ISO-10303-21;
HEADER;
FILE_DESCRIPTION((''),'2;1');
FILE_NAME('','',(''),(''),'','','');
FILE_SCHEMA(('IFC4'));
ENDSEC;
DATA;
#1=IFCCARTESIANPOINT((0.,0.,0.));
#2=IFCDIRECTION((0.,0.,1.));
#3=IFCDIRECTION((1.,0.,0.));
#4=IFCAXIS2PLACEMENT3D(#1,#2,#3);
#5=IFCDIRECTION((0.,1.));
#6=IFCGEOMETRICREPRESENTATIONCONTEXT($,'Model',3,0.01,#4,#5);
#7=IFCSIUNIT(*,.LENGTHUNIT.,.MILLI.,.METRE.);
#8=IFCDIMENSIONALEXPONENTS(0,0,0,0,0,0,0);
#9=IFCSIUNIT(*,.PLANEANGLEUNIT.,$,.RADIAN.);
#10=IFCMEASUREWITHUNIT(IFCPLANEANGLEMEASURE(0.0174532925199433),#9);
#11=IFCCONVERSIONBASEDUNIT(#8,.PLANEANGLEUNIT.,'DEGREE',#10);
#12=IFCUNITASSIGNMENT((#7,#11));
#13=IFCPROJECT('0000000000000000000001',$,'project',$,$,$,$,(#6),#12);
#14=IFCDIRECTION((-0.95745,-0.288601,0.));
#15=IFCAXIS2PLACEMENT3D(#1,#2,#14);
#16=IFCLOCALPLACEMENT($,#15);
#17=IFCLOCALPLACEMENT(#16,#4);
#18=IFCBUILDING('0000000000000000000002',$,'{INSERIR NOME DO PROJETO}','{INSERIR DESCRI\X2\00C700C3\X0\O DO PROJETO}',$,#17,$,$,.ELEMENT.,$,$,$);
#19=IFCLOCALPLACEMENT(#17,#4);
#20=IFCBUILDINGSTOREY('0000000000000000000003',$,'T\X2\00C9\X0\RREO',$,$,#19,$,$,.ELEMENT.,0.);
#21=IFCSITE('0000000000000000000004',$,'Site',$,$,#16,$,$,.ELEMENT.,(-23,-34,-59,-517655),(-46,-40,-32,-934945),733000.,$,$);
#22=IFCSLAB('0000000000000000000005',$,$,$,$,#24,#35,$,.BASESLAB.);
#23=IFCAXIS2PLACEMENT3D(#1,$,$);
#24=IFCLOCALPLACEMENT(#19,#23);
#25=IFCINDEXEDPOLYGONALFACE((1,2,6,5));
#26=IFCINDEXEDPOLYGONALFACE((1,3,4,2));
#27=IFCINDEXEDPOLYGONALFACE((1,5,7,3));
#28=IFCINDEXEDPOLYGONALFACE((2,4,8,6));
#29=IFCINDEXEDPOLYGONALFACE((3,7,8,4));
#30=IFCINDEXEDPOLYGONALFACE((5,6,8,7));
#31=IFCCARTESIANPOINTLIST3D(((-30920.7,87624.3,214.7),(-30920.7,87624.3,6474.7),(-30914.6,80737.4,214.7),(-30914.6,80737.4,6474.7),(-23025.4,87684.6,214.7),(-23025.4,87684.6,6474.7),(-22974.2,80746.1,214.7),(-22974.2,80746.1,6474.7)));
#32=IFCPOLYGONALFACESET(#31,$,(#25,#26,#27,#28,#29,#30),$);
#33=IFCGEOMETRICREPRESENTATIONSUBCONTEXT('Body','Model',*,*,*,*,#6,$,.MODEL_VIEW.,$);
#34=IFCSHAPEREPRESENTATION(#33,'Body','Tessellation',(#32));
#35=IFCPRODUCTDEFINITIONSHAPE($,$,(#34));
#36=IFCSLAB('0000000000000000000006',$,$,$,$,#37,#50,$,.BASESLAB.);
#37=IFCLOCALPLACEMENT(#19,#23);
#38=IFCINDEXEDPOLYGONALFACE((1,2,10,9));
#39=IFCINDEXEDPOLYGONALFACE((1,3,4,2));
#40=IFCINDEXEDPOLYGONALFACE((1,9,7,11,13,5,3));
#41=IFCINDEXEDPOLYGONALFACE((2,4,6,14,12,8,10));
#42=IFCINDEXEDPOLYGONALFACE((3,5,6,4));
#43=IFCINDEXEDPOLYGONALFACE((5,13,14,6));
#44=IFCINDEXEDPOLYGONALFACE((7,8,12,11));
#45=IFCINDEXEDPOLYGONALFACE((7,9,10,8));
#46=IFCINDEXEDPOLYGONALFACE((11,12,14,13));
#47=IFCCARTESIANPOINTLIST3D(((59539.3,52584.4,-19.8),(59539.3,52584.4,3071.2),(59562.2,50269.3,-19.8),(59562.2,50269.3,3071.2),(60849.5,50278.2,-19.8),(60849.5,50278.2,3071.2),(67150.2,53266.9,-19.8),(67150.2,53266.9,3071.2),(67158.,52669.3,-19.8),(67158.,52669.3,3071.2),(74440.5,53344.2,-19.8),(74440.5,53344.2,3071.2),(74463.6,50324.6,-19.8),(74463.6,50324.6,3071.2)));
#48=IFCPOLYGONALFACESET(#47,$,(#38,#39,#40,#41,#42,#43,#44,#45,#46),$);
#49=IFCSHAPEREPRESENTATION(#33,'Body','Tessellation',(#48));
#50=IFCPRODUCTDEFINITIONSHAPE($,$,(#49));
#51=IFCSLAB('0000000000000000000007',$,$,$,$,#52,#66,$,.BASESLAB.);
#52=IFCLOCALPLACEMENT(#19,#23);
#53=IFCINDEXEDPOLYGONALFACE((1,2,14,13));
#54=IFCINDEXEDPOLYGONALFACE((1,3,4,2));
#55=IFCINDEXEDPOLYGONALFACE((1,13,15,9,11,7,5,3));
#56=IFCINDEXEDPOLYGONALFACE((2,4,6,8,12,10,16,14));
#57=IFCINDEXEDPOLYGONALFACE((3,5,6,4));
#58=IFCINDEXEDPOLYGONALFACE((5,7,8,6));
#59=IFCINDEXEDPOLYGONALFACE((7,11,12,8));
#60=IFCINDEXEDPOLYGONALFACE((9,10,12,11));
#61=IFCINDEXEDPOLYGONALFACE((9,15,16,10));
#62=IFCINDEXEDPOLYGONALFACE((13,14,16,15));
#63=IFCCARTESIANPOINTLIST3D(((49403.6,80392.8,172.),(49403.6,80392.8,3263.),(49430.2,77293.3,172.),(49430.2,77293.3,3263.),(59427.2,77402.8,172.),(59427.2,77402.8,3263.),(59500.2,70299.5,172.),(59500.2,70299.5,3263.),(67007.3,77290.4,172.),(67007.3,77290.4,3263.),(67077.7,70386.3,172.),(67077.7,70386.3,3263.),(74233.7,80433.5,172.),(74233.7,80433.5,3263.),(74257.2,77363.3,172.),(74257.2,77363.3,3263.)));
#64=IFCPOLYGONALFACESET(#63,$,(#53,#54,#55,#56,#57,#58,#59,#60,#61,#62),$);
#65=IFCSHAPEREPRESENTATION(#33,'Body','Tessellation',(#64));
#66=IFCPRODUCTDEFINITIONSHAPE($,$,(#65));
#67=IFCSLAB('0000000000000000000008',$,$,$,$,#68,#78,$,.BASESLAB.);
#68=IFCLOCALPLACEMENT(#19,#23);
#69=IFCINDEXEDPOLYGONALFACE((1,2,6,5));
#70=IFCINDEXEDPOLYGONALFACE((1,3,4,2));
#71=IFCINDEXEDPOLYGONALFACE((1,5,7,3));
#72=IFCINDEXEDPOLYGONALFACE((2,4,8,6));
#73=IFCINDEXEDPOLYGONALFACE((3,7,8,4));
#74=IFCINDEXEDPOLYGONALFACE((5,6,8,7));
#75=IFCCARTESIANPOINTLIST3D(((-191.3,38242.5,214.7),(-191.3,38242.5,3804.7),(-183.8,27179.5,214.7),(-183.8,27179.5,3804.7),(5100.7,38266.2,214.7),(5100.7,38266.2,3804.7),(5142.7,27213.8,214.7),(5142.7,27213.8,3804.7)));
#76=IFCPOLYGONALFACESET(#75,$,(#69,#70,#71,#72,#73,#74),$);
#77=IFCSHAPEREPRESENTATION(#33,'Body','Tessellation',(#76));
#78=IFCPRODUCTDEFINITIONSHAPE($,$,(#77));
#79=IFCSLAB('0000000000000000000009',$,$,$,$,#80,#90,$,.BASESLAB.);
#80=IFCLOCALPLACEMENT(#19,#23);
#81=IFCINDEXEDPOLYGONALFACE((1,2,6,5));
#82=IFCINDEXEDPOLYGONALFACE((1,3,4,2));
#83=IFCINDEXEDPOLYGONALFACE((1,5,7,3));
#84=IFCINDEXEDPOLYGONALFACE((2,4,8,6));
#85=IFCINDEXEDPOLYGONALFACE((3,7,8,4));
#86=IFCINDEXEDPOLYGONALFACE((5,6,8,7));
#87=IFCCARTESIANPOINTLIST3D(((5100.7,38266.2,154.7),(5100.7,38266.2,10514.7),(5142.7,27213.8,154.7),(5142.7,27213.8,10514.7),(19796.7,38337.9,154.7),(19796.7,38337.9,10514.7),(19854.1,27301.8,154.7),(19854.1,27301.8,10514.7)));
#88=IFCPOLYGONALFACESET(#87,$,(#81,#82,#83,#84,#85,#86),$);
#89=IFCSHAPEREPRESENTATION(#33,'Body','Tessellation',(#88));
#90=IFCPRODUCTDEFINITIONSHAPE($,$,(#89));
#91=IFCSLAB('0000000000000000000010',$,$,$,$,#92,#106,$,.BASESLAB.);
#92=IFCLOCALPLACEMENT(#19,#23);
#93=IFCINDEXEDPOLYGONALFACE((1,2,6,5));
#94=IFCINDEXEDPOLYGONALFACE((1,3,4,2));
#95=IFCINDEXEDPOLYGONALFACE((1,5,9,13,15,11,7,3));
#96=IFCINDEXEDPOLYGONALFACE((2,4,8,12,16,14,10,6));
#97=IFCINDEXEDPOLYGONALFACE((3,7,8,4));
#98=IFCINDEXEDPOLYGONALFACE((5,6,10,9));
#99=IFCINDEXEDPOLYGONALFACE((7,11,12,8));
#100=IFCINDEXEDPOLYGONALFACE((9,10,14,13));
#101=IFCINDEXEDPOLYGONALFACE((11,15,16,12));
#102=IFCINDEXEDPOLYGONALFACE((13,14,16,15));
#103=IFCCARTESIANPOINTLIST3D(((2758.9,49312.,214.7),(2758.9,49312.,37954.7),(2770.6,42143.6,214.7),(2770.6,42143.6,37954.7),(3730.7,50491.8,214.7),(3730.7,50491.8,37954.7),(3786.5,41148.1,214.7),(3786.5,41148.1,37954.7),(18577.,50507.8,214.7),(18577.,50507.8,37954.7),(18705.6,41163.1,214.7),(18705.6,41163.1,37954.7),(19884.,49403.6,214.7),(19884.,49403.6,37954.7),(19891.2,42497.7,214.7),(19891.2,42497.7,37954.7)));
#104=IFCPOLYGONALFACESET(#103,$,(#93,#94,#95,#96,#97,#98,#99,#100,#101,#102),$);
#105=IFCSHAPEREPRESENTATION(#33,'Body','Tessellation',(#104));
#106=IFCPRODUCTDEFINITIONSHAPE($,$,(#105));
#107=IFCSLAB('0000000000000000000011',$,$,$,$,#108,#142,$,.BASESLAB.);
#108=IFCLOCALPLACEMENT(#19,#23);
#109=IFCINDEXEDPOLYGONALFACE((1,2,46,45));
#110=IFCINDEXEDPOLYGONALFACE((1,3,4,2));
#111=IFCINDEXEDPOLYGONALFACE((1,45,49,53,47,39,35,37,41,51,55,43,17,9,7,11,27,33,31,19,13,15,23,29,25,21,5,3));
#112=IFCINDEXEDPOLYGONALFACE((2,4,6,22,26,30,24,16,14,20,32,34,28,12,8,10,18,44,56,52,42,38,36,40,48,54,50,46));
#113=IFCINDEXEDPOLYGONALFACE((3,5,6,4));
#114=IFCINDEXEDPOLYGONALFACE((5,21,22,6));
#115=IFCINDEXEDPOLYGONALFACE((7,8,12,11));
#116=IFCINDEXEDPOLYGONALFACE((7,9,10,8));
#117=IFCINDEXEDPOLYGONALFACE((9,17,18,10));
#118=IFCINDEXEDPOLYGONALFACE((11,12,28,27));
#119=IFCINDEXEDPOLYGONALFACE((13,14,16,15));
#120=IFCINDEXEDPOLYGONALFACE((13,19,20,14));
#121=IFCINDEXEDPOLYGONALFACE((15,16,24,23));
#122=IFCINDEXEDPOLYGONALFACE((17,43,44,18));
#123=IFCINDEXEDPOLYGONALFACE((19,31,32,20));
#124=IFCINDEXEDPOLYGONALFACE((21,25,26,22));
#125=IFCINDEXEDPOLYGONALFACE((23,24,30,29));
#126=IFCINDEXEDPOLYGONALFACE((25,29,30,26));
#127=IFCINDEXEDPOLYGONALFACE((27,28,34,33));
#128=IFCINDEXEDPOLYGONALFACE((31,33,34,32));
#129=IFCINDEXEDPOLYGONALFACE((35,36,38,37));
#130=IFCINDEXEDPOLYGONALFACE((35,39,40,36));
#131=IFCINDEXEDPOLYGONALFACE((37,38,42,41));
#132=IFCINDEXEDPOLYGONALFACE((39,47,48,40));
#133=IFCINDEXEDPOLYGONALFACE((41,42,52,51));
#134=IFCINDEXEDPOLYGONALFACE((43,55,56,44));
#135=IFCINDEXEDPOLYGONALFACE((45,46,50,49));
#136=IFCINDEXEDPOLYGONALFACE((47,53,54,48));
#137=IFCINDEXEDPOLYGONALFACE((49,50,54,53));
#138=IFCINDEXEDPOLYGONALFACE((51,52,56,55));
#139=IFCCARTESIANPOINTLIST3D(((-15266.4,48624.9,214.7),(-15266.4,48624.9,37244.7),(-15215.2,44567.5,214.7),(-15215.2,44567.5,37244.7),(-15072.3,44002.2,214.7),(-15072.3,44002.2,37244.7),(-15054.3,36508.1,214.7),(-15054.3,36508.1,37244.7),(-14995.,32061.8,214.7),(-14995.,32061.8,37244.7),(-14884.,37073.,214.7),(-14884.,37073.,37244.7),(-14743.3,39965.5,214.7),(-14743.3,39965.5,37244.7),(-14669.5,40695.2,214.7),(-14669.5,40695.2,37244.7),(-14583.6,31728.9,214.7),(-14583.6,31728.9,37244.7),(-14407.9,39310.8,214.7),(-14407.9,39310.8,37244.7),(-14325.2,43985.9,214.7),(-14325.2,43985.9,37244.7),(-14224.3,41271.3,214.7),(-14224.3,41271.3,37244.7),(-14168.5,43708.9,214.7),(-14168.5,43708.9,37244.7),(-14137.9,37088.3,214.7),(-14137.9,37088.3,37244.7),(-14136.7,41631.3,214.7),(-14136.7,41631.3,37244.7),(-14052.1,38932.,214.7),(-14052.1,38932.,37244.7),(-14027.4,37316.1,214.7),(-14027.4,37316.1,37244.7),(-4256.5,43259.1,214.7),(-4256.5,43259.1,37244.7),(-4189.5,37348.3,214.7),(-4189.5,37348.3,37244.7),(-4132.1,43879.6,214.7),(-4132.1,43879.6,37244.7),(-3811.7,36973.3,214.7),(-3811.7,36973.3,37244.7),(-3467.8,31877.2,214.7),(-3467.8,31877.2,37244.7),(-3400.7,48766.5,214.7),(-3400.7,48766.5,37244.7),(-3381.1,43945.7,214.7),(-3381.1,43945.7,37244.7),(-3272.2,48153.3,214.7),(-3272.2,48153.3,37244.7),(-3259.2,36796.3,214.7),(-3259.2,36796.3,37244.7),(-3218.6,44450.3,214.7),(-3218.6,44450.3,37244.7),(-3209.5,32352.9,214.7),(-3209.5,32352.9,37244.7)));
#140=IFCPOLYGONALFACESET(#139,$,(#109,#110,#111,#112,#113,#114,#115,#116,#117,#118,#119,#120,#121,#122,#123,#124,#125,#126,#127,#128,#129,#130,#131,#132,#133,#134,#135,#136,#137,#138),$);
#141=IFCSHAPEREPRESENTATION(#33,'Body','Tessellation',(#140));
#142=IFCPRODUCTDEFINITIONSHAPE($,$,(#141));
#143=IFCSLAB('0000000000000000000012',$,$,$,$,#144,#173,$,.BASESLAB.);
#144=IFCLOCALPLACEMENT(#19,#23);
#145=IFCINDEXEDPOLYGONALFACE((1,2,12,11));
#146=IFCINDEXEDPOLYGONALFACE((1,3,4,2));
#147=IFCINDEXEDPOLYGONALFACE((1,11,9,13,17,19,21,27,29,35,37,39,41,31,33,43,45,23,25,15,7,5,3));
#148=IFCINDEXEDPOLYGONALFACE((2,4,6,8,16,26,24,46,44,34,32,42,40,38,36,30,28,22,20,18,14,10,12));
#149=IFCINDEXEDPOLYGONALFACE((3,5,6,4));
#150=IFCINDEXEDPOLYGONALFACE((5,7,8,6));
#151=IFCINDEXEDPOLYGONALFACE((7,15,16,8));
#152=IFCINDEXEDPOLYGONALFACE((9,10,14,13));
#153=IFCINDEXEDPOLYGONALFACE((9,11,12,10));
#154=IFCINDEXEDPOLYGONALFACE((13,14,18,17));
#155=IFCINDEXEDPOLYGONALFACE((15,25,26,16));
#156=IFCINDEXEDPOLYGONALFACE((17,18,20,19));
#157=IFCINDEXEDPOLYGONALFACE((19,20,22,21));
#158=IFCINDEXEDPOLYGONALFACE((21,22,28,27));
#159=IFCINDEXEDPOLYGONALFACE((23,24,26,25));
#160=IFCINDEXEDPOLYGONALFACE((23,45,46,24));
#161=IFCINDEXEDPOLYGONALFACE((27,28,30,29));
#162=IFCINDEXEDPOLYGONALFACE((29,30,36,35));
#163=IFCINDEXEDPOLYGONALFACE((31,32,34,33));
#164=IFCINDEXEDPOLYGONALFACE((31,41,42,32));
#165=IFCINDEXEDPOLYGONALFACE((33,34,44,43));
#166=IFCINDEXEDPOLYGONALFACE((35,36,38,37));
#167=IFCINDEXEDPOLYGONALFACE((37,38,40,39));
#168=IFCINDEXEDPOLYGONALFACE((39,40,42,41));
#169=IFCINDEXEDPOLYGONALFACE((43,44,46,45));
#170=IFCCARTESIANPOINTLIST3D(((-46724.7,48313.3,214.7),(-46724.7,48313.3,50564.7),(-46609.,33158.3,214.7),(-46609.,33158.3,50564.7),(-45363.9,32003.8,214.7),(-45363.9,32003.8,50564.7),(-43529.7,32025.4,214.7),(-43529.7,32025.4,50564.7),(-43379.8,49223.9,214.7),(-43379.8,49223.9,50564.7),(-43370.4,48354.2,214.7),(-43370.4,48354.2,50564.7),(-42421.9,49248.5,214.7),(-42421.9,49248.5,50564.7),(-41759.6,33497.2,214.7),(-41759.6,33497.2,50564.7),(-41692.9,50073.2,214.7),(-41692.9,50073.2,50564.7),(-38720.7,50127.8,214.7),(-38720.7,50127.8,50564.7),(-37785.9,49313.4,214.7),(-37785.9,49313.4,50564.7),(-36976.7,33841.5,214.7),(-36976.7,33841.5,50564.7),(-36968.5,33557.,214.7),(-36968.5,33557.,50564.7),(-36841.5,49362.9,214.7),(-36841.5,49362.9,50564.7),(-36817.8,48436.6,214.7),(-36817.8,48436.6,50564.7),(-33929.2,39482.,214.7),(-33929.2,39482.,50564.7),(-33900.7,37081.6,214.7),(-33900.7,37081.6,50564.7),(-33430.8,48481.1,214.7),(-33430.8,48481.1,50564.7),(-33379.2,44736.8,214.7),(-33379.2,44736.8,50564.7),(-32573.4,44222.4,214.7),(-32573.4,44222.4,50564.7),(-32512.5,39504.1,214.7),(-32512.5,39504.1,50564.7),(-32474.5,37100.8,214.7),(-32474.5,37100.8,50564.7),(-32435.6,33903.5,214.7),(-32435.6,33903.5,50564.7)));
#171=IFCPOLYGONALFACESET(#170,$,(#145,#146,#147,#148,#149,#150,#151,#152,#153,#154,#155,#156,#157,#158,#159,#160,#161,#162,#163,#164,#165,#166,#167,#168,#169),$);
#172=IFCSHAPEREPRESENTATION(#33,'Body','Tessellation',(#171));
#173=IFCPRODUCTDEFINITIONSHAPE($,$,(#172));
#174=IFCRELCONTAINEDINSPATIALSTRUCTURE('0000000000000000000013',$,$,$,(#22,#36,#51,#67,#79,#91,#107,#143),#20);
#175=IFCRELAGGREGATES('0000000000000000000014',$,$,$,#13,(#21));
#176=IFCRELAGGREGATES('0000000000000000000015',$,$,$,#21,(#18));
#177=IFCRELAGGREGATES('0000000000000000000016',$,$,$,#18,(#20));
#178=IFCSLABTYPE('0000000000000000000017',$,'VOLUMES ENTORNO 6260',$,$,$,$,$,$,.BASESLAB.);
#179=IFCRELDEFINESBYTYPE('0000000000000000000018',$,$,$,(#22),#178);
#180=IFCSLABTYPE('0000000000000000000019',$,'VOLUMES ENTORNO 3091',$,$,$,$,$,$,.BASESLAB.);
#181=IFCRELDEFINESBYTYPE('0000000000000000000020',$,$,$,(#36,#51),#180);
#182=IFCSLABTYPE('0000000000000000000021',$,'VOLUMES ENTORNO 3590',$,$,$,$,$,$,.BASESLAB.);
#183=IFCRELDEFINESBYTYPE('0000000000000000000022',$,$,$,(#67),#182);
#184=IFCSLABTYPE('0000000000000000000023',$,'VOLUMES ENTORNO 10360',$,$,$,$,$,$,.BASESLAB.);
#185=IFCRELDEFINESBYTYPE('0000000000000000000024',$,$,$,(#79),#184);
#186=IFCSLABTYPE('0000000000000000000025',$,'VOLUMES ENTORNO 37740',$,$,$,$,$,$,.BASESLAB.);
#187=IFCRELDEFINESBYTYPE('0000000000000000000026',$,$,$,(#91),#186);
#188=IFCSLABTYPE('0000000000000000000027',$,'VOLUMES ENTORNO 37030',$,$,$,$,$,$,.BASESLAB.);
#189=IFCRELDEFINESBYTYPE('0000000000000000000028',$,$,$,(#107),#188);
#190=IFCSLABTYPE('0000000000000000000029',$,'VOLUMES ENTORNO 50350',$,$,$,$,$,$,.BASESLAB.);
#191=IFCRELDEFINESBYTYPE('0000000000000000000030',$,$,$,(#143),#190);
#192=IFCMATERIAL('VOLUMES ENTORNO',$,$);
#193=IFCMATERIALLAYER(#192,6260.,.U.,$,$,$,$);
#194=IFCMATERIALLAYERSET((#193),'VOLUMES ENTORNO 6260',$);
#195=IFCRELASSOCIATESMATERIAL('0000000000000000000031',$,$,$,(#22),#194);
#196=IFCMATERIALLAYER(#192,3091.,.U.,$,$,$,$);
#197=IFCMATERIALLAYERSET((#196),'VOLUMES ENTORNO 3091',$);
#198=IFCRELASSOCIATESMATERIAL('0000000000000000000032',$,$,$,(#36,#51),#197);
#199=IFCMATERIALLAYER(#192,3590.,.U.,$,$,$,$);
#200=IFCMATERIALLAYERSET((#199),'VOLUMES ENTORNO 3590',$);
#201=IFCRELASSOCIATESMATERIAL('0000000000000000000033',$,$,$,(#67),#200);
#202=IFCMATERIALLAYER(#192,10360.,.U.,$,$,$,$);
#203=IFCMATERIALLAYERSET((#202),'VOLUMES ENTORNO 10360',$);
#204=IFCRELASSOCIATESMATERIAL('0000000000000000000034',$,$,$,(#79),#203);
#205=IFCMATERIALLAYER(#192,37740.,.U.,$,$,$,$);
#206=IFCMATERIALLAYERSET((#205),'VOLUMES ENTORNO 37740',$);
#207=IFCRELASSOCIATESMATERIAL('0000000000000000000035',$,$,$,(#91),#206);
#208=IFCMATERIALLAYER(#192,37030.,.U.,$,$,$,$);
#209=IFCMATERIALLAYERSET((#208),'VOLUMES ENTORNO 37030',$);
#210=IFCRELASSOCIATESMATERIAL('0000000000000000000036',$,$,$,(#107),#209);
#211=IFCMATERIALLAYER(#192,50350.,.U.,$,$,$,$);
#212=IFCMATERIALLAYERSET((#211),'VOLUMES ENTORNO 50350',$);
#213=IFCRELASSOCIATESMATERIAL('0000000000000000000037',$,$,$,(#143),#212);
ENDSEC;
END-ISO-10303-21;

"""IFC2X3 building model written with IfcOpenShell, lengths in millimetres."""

from ifc_helpers import new_model, entity, si_unit, converted_unit, direction, frame, origin_with_axes, place, context, subcontext, project, spatial, polyline, outline, extrude, material, layer, layer_set, layer_usage, type_object, element, save


model = new_model("IFC2X3")

# Units and contexts
model_context = context("Model", 3, precision=0.01, world=origin_with_axes(), true_north=direction((0.0, 1.0)))
body_context = subcontext(model_context, "Body", "Model", "MODEL_VIEW")
ifc_project = project(units=[si_unit("LENGTHUNIT", "METRE", prefix="MILLI"), converted_unit("PLANEANGLEUNIT", "DEGREE", entity("IfcPlaneAngleMeasure", 0.0174532925199433), si_unit("PLANEANGLEUNIT", "RADIAN"), dimensions=[0, 0, 0, 0, 0, 0, 0])], contexts=[model_context])

# Site, building, storey
site_placement = place(None, frame((0.0, 0.0, 0.0), z_axis=(0.0, 0.0, 1.0), x_axis=(-0.95745, -0.288601, 0.0)))
site = spatial("IfcSite", under=ifc_project, at=site_placement, Name="Site", CompositionType="ELEMENT", RefLatitude=(-23, -34, -59, -517655), RefLongitude=(-46, -40, -32, -934945), RefElevation=733000.0)
building_placement = place(site_placement, origin_with_axes())
building = spatial("IfcBuilding", under=site, at=building_placement, Name="{INSERIR NOME DO PROJETO}", Description="{INSERIR DESCRIÇÃO DO PROJETO}", CompositionType="ELEMENT")
storey_placement = place(building_placement, origin_with_axes())
storey = spatial("IfcBuildingStorey", under=building, at=storey_placement, Name="TÉRREO", CompositionType="ELEMENT", Elevation=0.0)

# Slabs
ifc_material_1 = material(Name="VOLUMES ENTORNO")
ifc_layer_1 = layer(ifc_material_1, 6260.0, ventilated="UNKNOWN")
ifc_layer_set_1 = layer_set([ifc_layer_1], Name="VOLUMES ENTORNO 6260")
ifc_layer_usage_1 = layer_usage(ifc_layer_set_1, "AXIS3", "NEGATIVE", 6260.0)
slab_type_1 = type_object("IfcSlabType", Name="VOLUMES ENTORNO 6260", PredefinedType="BASESLAB")
slab_1_placement = place(storey_placement, frame((-22974.2, 80746.1, 214.7), z_axis=(0.0, 0.0, 1.0), x_axis=(1.0, 0.0, 0.0)))
element("IfcSlab", 1, at=slab_1_placement, inside=storey, type_object=slab_type_1, material=ifc_layer_usage_1, PredefinedType="BASESLAB", context=body_context, shape_type="SweptSolid", body=[
    extrude(outline(polyline([(0.0, 0.0), (-51.2, 6938.5), (-7946.5, 6878.2), (-7940.4, -8.8), (0.0, 0.0)])), origin_with_axes(), (0.0, 0.0, 1.0), 6260.0),
])
ifc_layer_2 = layer(ifc_material_1, 3091.0, ventilated="UNKNOWN")
ifc_layer_set_2 = layer_set([ifc_layer_2], Name="VOLUMES ENTORNO 3091")
ifc_layer_usage_2 = layer_usage(ifc_layer_set_2, "AXIS3", "NEGATIVE", 3091.0)
slab_type_2 = type_object("IfcSlabType", Name="VOLUMES ENTORNO 3091", PredefinedType="BASESLAB")
slab_2_placement = place(storey_placement, frame((67150.2, 53266.9, -19.8), z_axis=(0.0, 0.0, 1.0), x_axis=(1.0, 0.0, 0.0)))
element("IfcSlab", 2, at=slab_2_placement, inside=storey, type_object=slab_type_2, material=ifc_layer_usage_2, PredefinedType="BASESLAB", context=body_context, shape_type="SweptSolid", body=[
    extrude(outline(polyline([(0.0, 0.0), (7.8, -597.7), (-7610.8, -682.6), (-7588.0, -2997.6), (-6300.7, -2988.8), (7313.5, -2942.4), (7290.4, 77.3), (0.0, 0.0)])), origin_with_axes(), (0.0, 0.0, 1.0), 3091.0),
])
ifc_layer_usage_3 = layer_usage(ifc_layer_set_2, "AXIS3", "NEGATIVE", 3091.0)
slab_3_placement = place(storey_placement, frame((49430.2, 77293.3, 172.0), z_axis=(0.0, 0.0, 1.0), x_axis=(1.0, 0.0, 0.0)))
element("IfcSlab", 3, at=slab_3_placement, inside=storey, type_object=slab_type_2, material=ifc_layer_usage_3, PredefinedType="BASESLAB", context=body_context, shape_type="SweptSolid", body=[
    extrude(outline(polyline([(0.0, 0.0), (9997.0, 109.5), (10070.1, -6993.8), (17647.5, -6907.0), (17577.1, -2.9), (24827.0, 70.0), (24803.5, 3140.2), (-26.6, 3099.6), (0.0, 0.0)])), origin_with_axes(), (0.0, 0.0, 1.0), 3091.0),
])
ifc_layer_3 = layer(ifc_material_1, 3590.0, ventilated="UNKNOWN")
ifc_layer_set_3 = layer_set([ifc_layer_3], Name="VOLUMES ENTORNO 3590")
ifc_layer_usage_4 = layer_usage(ifc_layer_set_3, "AXIS3", "NEGATIVE", 3590.0)
slab_type_3 = type_object("IfcSlabType", Name="VOLUMES ENTORNO 3590", PredefinedType="BASESLAB")
slab_4_placement = place(storey_placement, frame((5142.7, 27213.8, 214.7), z_axis=(0.0, 0.0, 1.0), x_axis=(1.0, 0.0, 0.0)))
element("IfcSlab", 4, at=slab_4_placement, inside=storey, type_object=slab_type_3, material=ifc_layer_usage_4, PredefinedType="BASESLAB", context=body_context, shape_type="SweptSolid", body=[
    extrude(outline(polyline([(0.0, 0.0), (-42.1, 11052.4), (-5334.1, 11028.7), (-5326.5, -34.2), (0.0, 0.0)])), origin_with_axes(), (0.0, 0.0, 1.0), 3590.0),
])
ifc_layer_4 = layer(ifc_material_1, 10360.0, ventilated="UNKNOWN")
ifc_layer_set_4 = layer_set([ifc_layer_4], Name="VOLUMES ENTORNO 10360")
ifc_layer_usage_5 = layer_usage(ifc_layer_set_4, "AXIS3", "NEGATIVE", 10360.0)
slab_type_4 = type_object("IfcSlabType", Name="VOLUMES ENTORNO 10360", PredefinedType="BASESLAB")
slab_5_placement = place(storey_placement, frame((5142.7, 27213.8, 154.7), z_axis=(0.0, 0.0, 1.0), x_axis=(1.0, 0.0, 0.0)))
element("IfcSlab", 5, at=slab_5_placement, inside=storey, type_object=slab_type_4, material=ifc_layer_usage_5, PredefinedType="BASESLAB", context=body_context, shape_type="SweptSolid", body=[
    extrude(outline(polyline([(0.0, 0.0), (14711.4, 88.0), (14654.0, 11124.2), (-42.1, 11052.4), (0.0, 0.0)])), origin_with_axes(), (0.0, 0.0, 1.0), 10360.0),
])
ifc_layer_5 = layer(ifc_material_1, 37740.0, ventilated="UNKNOWN")
ifc_layer_set_5 = layer_set([ifc_layer_5], Name="VOLUMES ENTORNO 37740")
ifc_layer_usage_6 = layer_usage(ifc_layer_set_5, "AXIS3", "NEGATIVE", 37740.0)
slab_type_5 = type_object("IfcSlabType", Name="VOLUMES ENTORNO 37740", PredefinedType="BASESLAB")
slab_6_placement = place(storey_placement, frame((19891.2, 42497.7, 214.7), z_axis=(0.0, 0.0, 1.0), x_axis=(1.0, 0.0, 0.0)))
element("IfcSlab", 6, at=slab_6_placement, inside=storey, type_object=slab_type_5, material=ifc_layer_usage_6, PredefinedType="BASESLAB", context=body_context, shape_type="SweptSolid", body=[
    extrude(outline(polyline([(0.0, 0.0), (-7.2, 6905.9), (-1314.2, 8010.1), (-16160.5, 7994.1), (-17132.4, 6814.4), (-17120.7, -354.0), (-16104.8, -1349.6), (-1185.6, -1334.6), (0.0, 0.0)])), origin_with_axes(), (0.0, 0.0, 1.0), 37740.0),
])
ifc_layer_6 = layer(ifc_material_1, 37030.0, ventilated="UNKNOWN")
ifc_layer_set_6 = layer_set([ifc_layer_6], Name="VOLUMES ENTORNO 37030")
ifc_layer_usage_7 = layer_usage(ifc_layer_set_6, "AXIS3", "NEGATIVE", 37030.0)
slab_type_6 = type_object("IfcSlabType", Name="VOLUMES ENTORNO 37030", PredefinedType="BASESLAB")
slab_7_placement = place(storey_placement, frame((-14168.5, 43708.9, 214.7), z_axis=(0.0, 0.0, 1.0), x_axis=(1.0, 0.0, 0.0)))
element("IfcSlab", 7, at=slab_7_placement, inside=storey, type_object=slab_type_6, material=ifc_layer_usage_7, PredefinedType="BASESLAB", context=body_context, shape_type="SweptSolid", body=[
    extrude(outline(polyline([(0.0, 0.0), (31.8, -2077.6), (-55.9, -2437.6), (-501.1, -3013.6), (-574.8, -3743.4), (-239.5, -4398.0), (116.4, -4776.8), (141.1, -6392.7), (30.6, -6620.5), (-715.6, -6635.8), (-885.8, -7200.7), (-826.5, -11647.1), (-415.1, -11980.0), (10700.7, -11831.7), (10959.0, -11356.0), (10909.2, -6912.5), (10356.8, -6735.6), (9978.9, -6360.6), (9912.0, -449.7), (10036.3, 170.8), (10787.4, 236.8), (10949.9, 741.4), (10896.3, 4444.4), (10767.8, 5057.6), (-1097.9, 4916.0), (-1046.7, 858.6), (-903.8, 293.3), (-156.7, 277.0), (0.0, 0.0)])), origin_with_axes(), (0.0, 0.0, 1.0), 37030.0),
])
ifc_layer_7 = layer(ifc_material_1, 50350.0, ventilated="UNKNOWN")
ifc_layer_set_7 = layer_set([ifc_layer_7], Name="VOLUMES ENTORNO 50350")
ifc_layer_usage_8 = layer_usage(ifc_layer_set_7, "AXIS3", "NEGATIVE", 50350.0)
slab_type_7 = type_object("IfcSlabType", Name="VOLUMES ENTORNO 50350", PredefinedType="BASESLAB")
slab_8_placement = place(storey_placement, frame((-43529.7, 32025.4, 214.7), z_axis=(0.0, 0.0, 1.0), x_axis=(1.0, 0.0, 0.0)))
element("IfcSlab", 8, at=slab_8_placement, inside=storey, type_object=slab_type_7, material=ifc_layer_usage_8, PredefinedType="BASESLAB", context=body_context, shape_type="SweptSolid", body=[
    extrude(outline(polyline([(0.0, 0.0), (1770.1, 1471.8), (6561.2, 1531.6), (6553.0, 1816.1), (11094.1, 1878.2), (11055.2, 5075.4), (9628.9, 5056.2), (9600.5, 7456.6), (11017.1, 7478.7), (10956.3, 12197.0), (10150.4, 12711.5), (10098.8, 16455.7), (6711.9, 16411.2), (6688.2, 17337.5), (5743.7, 17288.0), (4809.0, 18102.4), (1836.8, 18047.8), (1107.8, 17223.2), (149.9, 17198.5), (159.3, 16328.8), (-3195.0, 16287.9), (-3079.3, 1133.0), (-1834.3, -21.5), (0.0, 0.0)])), origin_with_axes(), (0.0, 0.0, 1.0), 50350.0),
])

save(model, "model.ifc")
